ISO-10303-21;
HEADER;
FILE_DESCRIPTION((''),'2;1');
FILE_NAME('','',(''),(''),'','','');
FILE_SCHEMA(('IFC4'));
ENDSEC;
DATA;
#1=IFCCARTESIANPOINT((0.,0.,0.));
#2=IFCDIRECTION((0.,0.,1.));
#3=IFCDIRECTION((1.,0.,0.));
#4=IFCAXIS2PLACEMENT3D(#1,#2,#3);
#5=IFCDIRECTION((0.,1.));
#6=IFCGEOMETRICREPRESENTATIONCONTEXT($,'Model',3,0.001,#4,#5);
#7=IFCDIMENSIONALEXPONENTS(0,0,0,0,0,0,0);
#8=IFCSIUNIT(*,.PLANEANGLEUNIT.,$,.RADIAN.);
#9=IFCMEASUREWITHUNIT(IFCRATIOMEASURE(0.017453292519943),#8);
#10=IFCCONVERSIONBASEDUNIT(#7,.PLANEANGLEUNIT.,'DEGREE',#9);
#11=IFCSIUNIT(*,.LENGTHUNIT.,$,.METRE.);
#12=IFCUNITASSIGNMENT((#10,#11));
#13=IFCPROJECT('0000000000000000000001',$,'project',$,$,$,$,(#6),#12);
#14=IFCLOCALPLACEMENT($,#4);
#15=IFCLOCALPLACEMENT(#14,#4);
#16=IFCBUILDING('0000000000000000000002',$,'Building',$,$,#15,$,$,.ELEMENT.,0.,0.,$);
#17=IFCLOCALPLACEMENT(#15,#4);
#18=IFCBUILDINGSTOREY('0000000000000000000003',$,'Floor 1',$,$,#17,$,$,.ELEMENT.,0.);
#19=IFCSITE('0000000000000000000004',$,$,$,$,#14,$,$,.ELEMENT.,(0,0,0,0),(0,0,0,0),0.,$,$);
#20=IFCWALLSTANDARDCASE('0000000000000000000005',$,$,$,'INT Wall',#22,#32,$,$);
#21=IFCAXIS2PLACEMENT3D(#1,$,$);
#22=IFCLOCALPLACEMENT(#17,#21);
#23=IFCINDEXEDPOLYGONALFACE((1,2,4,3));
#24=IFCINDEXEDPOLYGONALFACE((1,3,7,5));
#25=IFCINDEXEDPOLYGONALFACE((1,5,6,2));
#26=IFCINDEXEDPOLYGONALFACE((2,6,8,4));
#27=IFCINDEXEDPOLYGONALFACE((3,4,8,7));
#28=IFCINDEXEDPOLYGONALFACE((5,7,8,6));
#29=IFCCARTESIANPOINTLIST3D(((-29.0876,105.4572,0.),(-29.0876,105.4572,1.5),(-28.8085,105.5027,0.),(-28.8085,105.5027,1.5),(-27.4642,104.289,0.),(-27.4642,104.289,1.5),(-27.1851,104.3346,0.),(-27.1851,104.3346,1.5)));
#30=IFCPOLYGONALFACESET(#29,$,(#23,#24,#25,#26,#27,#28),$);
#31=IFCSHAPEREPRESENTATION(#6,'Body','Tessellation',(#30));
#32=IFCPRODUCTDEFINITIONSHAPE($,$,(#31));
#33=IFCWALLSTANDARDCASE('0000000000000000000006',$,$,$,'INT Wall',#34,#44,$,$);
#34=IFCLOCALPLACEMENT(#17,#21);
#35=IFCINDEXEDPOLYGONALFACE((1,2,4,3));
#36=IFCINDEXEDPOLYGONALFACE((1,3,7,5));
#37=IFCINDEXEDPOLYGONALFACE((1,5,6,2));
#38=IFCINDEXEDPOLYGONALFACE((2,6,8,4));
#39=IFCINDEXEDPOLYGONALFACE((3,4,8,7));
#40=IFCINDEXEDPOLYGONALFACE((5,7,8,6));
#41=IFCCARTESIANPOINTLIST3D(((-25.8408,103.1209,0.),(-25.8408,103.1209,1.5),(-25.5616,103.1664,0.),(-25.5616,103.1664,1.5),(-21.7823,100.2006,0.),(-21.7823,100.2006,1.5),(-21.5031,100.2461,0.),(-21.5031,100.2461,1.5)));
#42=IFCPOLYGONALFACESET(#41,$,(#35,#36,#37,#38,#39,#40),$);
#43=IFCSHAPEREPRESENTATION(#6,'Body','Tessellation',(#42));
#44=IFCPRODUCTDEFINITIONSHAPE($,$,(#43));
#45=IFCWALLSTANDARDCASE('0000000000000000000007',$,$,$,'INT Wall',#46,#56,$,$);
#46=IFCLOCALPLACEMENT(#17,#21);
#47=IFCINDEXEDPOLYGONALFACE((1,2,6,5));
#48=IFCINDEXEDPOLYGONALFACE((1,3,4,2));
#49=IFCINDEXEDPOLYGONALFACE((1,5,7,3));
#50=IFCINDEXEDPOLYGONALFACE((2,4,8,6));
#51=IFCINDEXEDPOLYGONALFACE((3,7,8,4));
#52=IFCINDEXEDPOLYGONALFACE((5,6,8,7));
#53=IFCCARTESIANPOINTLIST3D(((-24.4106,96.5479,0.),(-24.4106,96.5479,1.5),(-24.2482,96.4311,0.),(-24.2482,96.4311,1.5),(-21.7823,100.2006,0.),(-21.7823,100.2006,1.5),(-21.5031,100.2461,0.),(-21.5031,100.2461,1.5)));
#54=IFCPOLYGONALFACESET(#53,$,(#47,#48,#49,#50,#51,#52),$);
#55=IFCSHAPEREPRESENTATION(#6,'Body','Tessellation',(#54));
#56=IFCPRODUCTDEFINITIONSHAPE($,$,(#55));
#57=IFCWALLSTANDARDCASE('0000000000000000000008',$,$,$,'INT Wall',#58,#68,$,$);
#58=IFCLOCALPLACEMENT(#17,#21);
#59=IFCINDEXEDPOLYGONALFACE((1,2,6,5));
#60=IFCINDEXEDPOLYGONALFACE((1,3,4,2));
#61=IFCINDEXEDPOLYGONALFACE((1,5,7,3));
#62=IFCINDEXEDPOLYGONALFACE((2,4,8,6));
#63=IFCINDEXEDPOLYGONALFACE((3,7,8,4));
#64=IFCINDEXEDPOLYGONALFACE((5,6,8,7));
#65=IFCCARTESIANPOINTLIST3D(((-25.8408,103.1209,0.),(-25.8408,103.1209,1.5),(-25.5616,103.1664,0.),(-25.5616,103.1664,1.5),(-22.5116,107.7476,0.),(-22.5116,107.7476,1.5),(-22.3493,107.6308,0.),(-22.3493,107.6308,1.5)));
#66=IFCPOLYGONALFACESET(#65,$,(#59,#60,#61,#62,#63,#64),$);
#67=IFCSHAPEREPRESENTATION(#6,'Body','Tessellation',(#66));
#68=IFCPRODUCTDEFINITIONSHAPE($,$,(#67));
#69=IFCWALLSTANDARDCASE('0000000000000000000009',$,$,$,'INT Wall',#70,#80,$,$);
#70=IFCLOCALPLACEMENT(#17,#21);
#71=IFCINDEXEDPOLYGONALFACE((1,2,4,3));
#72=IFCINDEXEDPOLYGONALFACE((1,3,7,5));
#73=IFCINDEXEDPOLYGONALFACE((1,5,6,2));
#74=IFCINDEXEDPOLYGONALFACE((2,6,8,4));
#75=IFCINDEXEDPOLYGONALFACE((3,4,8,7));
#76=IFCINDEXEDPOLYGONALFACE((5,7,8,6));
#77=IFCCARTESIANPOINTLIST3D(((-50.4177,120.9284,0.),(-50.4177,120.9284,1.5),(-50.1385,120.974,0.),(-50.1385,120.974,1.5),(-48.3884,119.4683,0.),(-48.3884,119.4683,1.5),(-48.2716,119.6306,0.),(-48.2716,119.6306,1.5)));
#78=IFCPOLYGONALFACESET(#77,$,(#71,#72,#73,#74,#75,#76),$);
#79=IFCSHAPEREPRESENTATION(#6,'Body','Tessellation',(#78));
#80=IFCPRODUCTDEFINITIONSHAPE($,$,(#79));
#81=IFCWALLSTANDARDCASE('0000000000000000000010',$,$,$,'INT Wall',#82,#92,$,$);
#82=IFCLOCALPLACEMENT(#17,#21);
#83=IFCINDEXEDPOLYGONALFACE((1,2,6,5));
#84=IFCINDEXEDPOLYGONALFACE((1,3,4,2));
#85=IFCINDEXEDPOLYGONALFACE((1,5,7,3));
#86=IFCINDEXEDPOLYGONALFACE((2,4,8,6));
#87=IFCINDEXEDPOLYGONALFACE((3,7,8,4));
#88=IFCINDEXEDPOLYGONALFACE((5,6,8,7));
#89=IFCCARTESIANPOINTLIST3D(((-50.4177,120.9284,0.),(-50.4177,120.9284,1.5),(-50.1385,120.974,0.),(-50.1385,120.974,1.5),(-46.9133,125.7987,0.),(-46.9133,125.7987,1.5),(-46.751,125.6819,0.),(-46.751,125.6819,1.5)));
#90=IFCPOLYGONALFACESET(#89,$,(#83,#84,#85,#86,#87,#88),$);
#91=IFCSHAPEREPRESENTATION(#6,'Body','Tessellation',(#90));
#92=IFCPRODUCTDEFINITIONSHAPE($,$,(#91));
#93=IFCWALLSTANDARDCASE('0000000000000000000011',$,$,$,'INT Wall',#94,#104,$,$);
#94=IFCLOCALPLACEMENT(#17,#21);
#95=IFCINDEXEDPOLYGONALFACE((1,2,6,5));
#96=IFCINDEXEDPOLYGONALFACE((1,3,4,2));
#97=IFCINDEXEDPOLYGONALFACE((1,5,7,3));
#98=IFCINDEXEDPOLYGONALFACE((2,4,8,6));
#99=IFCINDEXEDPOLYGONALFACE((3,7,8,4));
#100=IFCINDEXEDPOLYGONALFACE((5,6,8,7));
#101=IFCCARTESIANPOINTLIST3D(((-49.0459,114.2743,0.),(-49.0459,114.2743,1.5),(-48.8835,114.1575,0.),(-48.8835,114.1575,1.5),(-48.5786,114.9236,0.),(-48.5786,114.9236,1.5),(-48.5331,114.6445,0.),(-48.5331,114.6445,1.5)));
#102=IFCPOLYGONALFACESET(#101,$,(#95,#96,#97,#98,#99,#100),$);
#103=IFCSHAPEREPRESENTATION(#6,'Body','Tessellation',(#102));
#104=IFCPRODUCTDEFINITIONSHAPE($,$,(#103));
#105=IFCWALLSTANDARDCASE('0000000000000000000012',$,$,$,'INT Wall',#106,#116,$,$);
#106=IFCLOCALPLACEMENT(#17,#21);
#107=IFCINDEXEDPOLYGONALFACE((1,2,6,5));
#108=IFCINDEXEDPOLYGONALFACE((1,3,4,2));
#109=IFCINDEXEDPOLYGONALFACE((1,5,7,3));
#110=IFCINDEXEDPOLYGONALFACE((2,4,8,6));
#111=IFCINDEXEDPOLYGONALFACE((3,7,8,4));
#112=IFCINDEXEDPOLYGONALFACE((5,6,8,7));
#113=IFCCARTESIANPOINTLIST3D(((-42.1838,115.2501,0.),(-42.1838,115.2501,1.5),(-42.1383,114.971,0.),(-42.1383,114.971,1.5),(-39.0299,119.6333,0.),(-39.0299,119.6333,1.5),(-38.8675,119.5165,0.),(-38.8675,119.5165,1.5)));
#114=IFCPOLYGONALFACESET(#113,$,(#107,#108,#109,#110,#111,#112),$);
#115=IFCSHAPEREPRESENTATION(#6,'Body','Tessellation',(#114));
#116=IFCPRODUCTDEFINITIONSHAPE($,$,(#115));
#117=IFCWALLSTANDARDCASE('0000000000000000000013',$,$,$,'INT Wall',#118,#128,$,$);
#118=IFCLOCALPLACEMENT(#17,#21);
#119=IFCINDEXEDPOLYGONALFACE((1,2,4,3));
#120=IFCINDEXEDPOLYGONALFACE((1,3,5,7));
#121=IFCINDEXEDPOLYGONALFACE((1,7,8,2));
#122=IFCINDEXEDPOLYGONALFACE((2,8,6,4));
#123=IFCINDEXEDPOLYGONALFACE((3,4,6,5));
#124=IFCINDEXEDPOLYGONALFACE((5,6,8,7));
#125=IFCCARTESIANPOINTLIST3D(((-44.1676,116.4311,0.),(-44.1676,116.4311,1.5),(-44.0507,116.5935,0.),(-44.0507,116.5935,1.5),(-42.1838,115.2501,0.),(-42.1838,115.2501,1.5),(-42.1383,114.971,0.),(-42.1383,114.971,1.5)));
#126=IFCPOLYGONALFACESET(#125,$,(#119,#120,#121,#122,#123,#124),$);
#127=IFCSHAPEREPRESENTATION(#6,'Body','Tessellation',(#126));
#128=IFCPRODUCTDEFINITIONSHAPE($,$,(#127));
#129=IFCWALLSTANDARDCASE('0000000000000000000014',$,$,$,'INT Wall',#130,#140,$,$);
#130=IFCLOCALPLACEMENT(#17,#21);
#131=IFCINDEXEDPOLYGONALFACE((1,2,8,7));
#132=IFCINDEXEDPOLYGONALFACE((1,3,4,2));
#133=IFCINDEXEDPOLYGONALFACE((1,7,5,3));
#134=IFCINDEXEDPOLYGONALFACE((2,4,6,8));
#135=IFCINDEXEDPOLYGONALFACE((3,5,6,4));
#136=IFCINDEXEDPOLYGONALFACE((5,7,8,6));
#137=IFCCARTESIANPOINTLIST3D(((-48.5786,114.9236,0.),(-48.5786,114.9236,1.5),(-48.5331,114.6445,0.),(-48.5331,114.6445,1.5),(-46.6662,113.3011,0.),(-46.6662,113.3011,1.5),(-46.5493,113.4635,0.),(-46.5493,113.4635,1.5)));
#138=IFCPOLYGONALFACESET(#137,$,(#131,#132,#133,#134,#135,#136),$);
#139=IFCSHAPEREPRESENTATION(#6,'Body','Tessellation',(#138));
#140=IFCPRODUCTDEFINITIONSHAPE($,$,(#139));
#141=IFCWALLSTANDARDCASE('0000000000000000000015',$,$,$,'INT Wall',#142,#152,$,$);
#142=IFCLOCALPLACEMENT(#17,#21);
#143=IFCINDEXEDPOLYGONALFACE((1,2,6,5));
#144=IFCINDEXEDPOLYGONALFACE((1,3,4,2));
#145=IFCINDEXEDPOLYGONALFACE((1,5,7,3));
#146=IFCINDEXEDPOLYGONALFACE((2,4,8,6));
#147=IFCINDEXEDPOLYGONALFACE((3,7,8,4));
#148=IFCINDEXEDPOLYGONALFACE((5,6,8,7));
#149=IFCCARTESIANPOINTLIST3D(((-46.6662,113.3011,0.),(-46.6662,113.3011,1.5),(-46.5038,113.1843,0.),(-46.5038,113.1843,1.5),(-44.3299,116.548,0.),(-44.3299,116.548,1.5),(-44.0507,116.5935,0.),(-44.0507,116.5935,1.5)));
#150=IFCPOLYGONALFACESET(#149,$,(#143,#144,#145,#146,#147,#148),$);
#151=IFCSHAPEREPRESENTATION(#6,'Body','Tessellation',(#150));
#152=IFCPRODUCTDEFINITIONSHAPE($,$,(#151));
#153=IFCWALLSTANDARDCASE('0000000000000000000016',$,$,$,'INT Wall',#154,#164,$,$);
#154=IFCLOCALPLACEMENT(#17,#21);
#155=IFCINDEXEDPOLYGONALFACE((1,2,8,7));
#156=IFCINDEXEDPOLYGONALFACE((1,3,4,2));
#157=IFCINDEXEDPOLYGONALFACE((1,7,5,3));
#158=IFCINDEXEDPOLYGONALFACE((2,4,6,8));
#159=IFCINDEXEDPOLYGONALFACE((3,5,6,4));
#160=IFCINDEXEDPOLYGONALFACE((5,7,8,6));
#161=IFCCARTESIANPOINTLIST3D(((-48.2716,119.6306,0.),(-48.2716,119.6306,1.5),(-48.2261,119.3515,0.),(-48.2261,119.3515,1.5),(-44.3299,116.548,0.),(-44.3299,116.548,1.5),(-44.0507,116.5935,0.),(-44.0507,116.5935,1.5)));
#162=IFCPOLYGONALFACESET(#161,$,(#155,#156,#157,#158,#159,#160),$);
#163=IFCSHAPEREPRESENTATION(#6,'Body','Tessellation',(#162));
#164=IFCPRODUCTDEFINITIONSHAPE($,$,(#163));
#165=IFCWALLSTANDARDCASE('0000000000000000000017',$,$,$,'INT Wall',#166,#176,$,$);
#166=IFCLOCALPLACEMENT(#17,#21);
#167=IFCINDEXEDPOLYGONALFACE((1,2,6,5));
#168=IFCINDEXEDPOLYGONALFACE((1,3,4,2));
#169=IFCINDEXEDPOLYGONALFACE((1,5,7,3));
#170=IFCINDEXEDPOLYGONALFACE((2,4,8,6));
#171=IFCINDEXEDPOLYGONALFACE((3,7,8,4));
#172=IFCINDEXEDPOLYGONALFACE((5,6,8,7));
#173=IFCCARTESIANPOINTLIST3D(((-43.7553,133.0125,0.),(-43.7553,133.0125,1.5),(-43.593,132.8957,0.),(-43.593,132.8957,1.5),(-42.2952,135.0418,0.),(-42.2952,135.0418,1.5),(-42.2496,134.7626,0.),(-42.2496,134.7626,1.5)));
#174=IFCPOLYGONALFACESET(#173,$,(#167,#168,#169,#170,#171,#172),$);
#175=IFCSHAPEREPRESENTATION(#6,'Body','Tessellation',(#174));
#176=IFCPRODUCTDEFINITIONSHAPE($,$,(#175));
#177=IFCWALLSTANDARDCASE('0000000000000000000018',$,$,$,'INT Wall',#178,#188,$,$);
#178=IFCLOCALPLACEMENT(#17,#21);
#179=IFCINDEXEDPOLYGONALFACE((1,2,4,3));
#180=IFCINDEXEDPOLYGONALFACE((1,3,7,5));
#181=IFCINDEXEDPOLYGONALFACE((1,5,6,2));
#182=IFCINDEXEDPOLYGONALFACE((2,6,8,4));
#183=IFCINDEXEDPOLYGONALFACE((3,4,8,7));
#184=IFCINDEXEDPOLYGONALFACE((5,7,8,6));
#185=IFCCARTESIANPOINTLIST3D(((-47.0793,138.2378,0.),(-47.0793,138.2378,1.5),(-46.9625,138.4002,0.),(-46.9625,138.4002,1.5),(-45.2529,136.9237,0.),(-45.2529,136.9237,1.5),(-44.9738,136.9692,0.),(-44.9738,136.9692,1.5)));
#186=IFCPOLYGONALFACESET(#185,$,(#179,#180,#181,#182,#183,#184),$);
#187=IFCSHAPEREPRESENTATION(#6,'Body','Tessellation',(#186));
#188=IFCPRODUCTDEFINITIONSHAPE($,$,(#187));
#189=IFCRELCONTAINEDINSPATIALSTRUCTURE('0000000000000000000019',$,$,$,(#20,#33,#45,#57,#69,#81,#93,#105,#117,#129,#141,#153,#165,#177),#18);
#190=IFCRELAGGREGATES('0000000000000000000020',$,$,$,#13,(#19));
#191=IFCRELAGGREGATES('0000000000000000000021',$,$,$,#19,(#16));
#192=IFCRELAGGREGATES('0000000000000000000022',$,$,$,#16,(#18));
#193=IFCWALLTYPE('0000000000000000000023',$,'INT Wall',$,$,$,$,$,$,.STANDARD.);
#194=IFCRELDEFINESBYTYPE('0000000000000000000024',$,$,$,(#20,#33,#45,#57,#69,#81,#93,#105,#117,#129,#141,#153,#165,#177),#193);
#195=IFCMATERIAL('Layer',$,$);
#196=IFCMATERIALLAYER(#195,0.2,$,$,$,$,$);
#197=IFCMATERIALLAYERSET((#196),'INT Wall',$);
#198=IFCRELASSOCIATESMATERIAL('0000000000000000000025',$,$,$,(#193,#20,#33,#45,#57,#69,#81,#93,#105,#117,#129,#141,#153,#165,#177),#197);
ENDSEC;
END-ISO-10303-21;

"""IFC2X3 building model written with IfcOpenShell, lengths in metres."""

from ifc_helpers import new_model, entity, si_unit, converted_unit, direction, frame, origin_with_axes, place, context, project, spatial, polyline, outline, extrude, material, layer, layer_set, layer_usage, type_object, element, save


model = new_model("IFC2X3")

# Units and contexts
model_context = context("Model", 3, precision=0.001, world=origin_with_axes(), true_north=direction((0.0, 1.0)))
ifc_project = project(units=[converted_unit("PLANEANGLEUNIT", "DEGREE", entity("IfcRatioMeasure", 0.017453292519943), si_unit("PLANEANGLEUNIT", "RADIAN"), dimensions=[0, 0, 0, 0, 0, 0, 0]), si_unit("LENGTHUNIT", "METRE")], contexts=[model_context])

# Site, building, storey
site_placement = place(None, origin_with_axes())
site = spatial("IfcSite", under=ifc_project, at=site_placement, CompositionType="ELEMENT", RefLatitude=(0, 0, 0, 0), RefLongitude=(0, 0, 0, 0), RefElevation=0.0)
building_placement = place(site_placement, origin_with_axes())
building = spatial("IfcBuilding", under=site, at=building_placement, Name="Building", CompositionType="ELEMENT", ElevationOfRefHeight=0.0, ElevationOfTerrain=0.0)
storey_placement = place(building_placement, origin_with_axes())
storey = spatial("IfcBuildingStorey", under=building, at=storey_placement, Name="Floor 1", CompositionType="ELEMENT", Elevation=0.0)

# Walls
ifc_material_1 = material(Name="Layer")
ifc_layer_1 = layer(ifc_material_1, 0.2)
ifc_layer_set_1 = layer_set([ifc_layer_1], Name="INT Wall")
ifc_layer_usage_1 = layer_usage(ifc_layer_set_1, "AXIS2", "POSITIVE", -0.1)
wall_type_1 = type_object("IfcWallType", Name="INT Wall", PredefinedType="STANDARD", material=ifc_layer_set_1)
wall_1_placement = place(site_placement, frame((-27.3246, 104.3118, 0.0), z_axis=(0.0, 0.0, 1.0), x_axis=(-0.811707, 0.584065, 0.0)))
element("IfcWallStandardCase", 1, at=wall_1_placement, inside=storey, type_object=wall_type_1, material=ifc_layer_usage_1, ObjectType="INT Wall", context=model_context, shape_type="SweptSolid", body=[
    extrude(outline(polyline([(1.9, -0.1), (2.1, 0.1), (0.1, 0.1), (-0.1, -0.1), (1.9, -0.1)])), origin_with_axes(), (0.0, 0.0, 1.0), 1.5),
])
wall_2_placement = place(site_placement, frame((-25.7012, 103.1437, 0.0), z_axis=(0.0, 0.0, 1.0), x_axis=(0.811707, -0.584065, 0.0)))
element("IfcWallStandardCase", 2, at=wall_2_placement, inside=storey, type_object=wall_type_1, material=ifc_layer_usage_1, ObjectType="INT Wall", context=model_context, shape_type="SweptSolid", body=[
    extrude(outline(polyline([(4.9, -0.1), (5.1, 0.1), (0.1, 0.1), (-0.1, -0.1), (4.9, -0.1)])), origin_with_axes(), (0.0, 0.0, 1.0), 1.5),
])
wall_3_placement = place(site_placement, frame((-21.6427, 100.2233, 0.0), z_axis=(0.0, 0.0, 1.0), x_axis=(-0.584065, -0.811707, 0.0)))
element("IfcWallStandardCase", 3, at=wall_3_placement, inside=storey, type_object=wall_type_1, material=ifc_layer_usage_1, ObjectType="INT Wall", context=model_context, shape_type="SweptSolid", body=[
    extrude(outline(polyline([(4.6, 0.1), (4.6, -0.1), (0.1, -0.1), (-0.1, 0.1), (4.6, 0.1)])), origin_with_axes(), (0.0, 0.0, 1.0), 1.5),
])
wall_4_placement = place(site_placement, frame((-25.7012, 103.1437, 0.0), z_axis=(0.0, 0.0, 1.0), x_axis=(0.584065, 0.811707, 0.0)))
element("IfcWallStandardCase", 4, at=wall_4_placement, inside=storey, type_object=wall_type_1, material=ifc_layer_usage_1, ObjectType="INT Wall", context=model_context, shape_type="SweptSolid", body=[
    extrude(outline(polyline([(5.6, 0.1), (5.6, -0.1), (0.1, -0.1), (-0.1, 0.1), (5.6, 0.1)])), origin_with_axes(), (0.0, 0.0, 1.0), 1.5),
])
wall_5_placement = place(site_placement, frame((-50.2781, 120.9512, 0.0), z_axis=(0.0, 0.0, 1.0), x_axis=(0.811707, -0.584065, 0.0)))
element("IfcWallStandardCase", 5, at=wall_5_placement, inside=storey, type_object=wall_type_1, material=ifc_layer_usage_1, ObjectType="INT Wall", context=model_context, shape_type="SweptSolid", body=[
    extrude(outline(polyline([(2.4, 0.1), (2.4, -0.1), (-0.1, -0.1), (0.1, 0.1), (2.4, 0.1)])), origin_with_axes(), (0.0, 0.0, 1.0), 1.5),
])
wall_6_placement = place(site_placement, frame((-46.8321, 125.7403, 0.0), z_axis=(0.0, 0.0, 1.0), x_axis=(-0.584065, -0.811707, 0.0)))
element("IfcWallStandardCase", 6, at=wall_6_placement, inside=storey, type_object=wall_type_1, material=ifc_layer_usage_1, ObjectType="INT Wall", context=model_context, shape_type="SweptSolid", body=[
    extrude(outline(polyline([(6.0, -0.1), (5.8, 0.1), (0.0, 0.1), (0.0, -0.1), (6.0, -0.1)])), origin_with_axes(), (0.0, 0.0, 1.0), 1.5),
])
wall_7_placement = place(site_placement, frame((-49.1983, 113.8912, 0.0), z_axis=(0.0, 0.0, 1.0), x_axis=(0.584065, 0.811707, 0.0)))
element("IfcWallStandardCase", 7, at=wall_7_placement, inside=storey, type_object=wall_type_1, material=ifc_layer_usage_1, ObjectType="INT Wall", context=model_context, shape_type="SweptSolid", body=[
    extrude(outline(polyline([(0.4, -0.1), (0.4, 0.1), (1.2, 0.1), (1.0, -0.1), (0.4, -0.1)])), origin_with_axes(), (0.0, 0.0, 1.0), 1.5),
])
wall_8_placement = place(site_placement, frame((-42.161, 115.1106, 0.0), z_axis=(0.0, 0.0, 1.0), x_axis=(0.584065, 0.811707, 0.0)))
element("IfcWallStandardCase", 8, at=wall_8_placement, inside=storey, type_object=wall_type_1, material=ifc_layer_usage_1, ObjectType="INT Wall", context=model_context, shape_type="SweptSolid", body=[
    extrude(outline(polyline([(5.5, 0.1), (5.5, -0.1), (-0.1, -0.1), (0.1, 0.1), (5.5, 0.1)])), origin_with_axes(), (0.0, 0.0, 1.0), 1.5),
])
wall_9_placement = place(site_placement, frame((-44.1903, 116.5707, 0.0), z_axis=(0.0, 0.0, 1.0), x_axis=(0.811707, -0.584065, 0.0)))
element("IfcWallStandardCase", 9, at=wall_9_placement, inside=storey, type_object=wall_type_1, material=ifc_layer_usage_1, ObjectType="INT Wall", context=model_context, shape_type="SweptSolid", body=[
    extrude(outline(polyline([(0.1, -0.1), (0.1, 0.1), (2.4, 0.1), (2.6, -0.1), (0.1, -0.1)])), origin_with_axes(), (0.0, 0.0, 1.0), 1.5),
])
wall_10_placement = place(site_placement, frame((-48.5558, 114.7841, 0.0), z_axis=(0.0, 0.0, 1.0), x_axis=(0.811707, -0.584065, 0.0)))
element("IfcWallStandardCase", 10, at=wall_10_placement, inside=storey, type_object=wall_type_1, material=ifc_layer_usage_1, ObjectType="INT Wall", context=model_context, shape_type="SweptSolid", body=[
    extrude(outline(polyline([(2.4, 0.1), (2.4, -0.1), (0.1, -0.1), (-0.1, 0.1), (2.4, 0.1)])), origin_with_axes(), (0.0, 0.0, 1.0), 1.5),
])
wall_11_placement = place(site_placement, frame((-44.1903, 116.5707, 0.0), z_axis=(0.0, 0.0, 1.0), x_axis=(-0.584065, -0.811707, 0.0)))
element("IfcWallStandardCase", 11, at=wall_11_placement, inside=storey, type_object=wall_type_1, material=ifc_layer_usage_1, ObjectType="INT Wall", context=model_context, shape_type="SweptSolid", body=[
    extrude(outline(polyline([(4.1, -0.1), (4.1, 0.1), (-0.1, 0.1), (0.1, -0.1), (4.1, -0.1)])), origin_with_axes(), (0.0, 0.0, 1.0), 1.5),
])
wall_12_placement = place(site_placement, frame((-48.2489, 119.491, 0.0), z_axis=(0.0, 0.0, 1.0), x_axis=(0.811707, -0.584065, 0.0)))
element("IfcWallStandardCase", 12, at=wall_12_placement, inside=storey, type_object=wall_type_1, material=ifc_layer_usage_1, ObjectType="INT Wall", context=model_context, shape_type="SweptSolid", body=[
    extrude(outline(polyline([(4.9, -0.1), (5.1, 0.1), (-0.1, 0.1), (0.1, -0.1), (4.9, -0.1)])), origin_with_axes(), (0.0, 0.0, 1.0), 1.5),
])
wall_13_placement = place(site_placement, frame((-42.2724, 134.9022, 0.0), z_axis=(0.0, 0.0, 1.0), x_axis=(-0.584065, -0.811707, 0.0)))
element("IfcWallStandardCase", 13, at=wall_13_placement, inside=storey, type_object=wall_type_1, material=ifc_layer_usage_1, ObjectType="INT Wall", context=model_context, shape_type="SweptSolid", body=[
    extrude(outline(polyline([(2.4, 0.1), (2.4, -0.1), (-0.1, -0.1), (0.1, 0.1), (2.4, 0.1)])), origin_with_axes(), (0.0, 0.0, 1.0), 1.5),
])
wall_14_placement = place(site_placement, frame((-45.1134, 136.9464, 0.0), z_axis=(0.0, 0.0, 1.0), x_axis=(-0.811707, 0.584065, 0.0)))
element("IfcWallStandardCase", 14, at=wall_14_placement, inside=storey, type_object=wall_type_1, material=ifc_layer_usage_1, ObjectType="INT Wall", context=model_context, shape_type="SweptSolid", body=[
    extrude(outline(polyline([(2.35, 0.1), (2.35, -0.1), (-0.1, -0.1), (0.1, 0.1), (2.35, 0.1)])), origin_with_axes(), (0.0, 0.0, 1.0), 1.5),
])

save(model, "model.ifc")
